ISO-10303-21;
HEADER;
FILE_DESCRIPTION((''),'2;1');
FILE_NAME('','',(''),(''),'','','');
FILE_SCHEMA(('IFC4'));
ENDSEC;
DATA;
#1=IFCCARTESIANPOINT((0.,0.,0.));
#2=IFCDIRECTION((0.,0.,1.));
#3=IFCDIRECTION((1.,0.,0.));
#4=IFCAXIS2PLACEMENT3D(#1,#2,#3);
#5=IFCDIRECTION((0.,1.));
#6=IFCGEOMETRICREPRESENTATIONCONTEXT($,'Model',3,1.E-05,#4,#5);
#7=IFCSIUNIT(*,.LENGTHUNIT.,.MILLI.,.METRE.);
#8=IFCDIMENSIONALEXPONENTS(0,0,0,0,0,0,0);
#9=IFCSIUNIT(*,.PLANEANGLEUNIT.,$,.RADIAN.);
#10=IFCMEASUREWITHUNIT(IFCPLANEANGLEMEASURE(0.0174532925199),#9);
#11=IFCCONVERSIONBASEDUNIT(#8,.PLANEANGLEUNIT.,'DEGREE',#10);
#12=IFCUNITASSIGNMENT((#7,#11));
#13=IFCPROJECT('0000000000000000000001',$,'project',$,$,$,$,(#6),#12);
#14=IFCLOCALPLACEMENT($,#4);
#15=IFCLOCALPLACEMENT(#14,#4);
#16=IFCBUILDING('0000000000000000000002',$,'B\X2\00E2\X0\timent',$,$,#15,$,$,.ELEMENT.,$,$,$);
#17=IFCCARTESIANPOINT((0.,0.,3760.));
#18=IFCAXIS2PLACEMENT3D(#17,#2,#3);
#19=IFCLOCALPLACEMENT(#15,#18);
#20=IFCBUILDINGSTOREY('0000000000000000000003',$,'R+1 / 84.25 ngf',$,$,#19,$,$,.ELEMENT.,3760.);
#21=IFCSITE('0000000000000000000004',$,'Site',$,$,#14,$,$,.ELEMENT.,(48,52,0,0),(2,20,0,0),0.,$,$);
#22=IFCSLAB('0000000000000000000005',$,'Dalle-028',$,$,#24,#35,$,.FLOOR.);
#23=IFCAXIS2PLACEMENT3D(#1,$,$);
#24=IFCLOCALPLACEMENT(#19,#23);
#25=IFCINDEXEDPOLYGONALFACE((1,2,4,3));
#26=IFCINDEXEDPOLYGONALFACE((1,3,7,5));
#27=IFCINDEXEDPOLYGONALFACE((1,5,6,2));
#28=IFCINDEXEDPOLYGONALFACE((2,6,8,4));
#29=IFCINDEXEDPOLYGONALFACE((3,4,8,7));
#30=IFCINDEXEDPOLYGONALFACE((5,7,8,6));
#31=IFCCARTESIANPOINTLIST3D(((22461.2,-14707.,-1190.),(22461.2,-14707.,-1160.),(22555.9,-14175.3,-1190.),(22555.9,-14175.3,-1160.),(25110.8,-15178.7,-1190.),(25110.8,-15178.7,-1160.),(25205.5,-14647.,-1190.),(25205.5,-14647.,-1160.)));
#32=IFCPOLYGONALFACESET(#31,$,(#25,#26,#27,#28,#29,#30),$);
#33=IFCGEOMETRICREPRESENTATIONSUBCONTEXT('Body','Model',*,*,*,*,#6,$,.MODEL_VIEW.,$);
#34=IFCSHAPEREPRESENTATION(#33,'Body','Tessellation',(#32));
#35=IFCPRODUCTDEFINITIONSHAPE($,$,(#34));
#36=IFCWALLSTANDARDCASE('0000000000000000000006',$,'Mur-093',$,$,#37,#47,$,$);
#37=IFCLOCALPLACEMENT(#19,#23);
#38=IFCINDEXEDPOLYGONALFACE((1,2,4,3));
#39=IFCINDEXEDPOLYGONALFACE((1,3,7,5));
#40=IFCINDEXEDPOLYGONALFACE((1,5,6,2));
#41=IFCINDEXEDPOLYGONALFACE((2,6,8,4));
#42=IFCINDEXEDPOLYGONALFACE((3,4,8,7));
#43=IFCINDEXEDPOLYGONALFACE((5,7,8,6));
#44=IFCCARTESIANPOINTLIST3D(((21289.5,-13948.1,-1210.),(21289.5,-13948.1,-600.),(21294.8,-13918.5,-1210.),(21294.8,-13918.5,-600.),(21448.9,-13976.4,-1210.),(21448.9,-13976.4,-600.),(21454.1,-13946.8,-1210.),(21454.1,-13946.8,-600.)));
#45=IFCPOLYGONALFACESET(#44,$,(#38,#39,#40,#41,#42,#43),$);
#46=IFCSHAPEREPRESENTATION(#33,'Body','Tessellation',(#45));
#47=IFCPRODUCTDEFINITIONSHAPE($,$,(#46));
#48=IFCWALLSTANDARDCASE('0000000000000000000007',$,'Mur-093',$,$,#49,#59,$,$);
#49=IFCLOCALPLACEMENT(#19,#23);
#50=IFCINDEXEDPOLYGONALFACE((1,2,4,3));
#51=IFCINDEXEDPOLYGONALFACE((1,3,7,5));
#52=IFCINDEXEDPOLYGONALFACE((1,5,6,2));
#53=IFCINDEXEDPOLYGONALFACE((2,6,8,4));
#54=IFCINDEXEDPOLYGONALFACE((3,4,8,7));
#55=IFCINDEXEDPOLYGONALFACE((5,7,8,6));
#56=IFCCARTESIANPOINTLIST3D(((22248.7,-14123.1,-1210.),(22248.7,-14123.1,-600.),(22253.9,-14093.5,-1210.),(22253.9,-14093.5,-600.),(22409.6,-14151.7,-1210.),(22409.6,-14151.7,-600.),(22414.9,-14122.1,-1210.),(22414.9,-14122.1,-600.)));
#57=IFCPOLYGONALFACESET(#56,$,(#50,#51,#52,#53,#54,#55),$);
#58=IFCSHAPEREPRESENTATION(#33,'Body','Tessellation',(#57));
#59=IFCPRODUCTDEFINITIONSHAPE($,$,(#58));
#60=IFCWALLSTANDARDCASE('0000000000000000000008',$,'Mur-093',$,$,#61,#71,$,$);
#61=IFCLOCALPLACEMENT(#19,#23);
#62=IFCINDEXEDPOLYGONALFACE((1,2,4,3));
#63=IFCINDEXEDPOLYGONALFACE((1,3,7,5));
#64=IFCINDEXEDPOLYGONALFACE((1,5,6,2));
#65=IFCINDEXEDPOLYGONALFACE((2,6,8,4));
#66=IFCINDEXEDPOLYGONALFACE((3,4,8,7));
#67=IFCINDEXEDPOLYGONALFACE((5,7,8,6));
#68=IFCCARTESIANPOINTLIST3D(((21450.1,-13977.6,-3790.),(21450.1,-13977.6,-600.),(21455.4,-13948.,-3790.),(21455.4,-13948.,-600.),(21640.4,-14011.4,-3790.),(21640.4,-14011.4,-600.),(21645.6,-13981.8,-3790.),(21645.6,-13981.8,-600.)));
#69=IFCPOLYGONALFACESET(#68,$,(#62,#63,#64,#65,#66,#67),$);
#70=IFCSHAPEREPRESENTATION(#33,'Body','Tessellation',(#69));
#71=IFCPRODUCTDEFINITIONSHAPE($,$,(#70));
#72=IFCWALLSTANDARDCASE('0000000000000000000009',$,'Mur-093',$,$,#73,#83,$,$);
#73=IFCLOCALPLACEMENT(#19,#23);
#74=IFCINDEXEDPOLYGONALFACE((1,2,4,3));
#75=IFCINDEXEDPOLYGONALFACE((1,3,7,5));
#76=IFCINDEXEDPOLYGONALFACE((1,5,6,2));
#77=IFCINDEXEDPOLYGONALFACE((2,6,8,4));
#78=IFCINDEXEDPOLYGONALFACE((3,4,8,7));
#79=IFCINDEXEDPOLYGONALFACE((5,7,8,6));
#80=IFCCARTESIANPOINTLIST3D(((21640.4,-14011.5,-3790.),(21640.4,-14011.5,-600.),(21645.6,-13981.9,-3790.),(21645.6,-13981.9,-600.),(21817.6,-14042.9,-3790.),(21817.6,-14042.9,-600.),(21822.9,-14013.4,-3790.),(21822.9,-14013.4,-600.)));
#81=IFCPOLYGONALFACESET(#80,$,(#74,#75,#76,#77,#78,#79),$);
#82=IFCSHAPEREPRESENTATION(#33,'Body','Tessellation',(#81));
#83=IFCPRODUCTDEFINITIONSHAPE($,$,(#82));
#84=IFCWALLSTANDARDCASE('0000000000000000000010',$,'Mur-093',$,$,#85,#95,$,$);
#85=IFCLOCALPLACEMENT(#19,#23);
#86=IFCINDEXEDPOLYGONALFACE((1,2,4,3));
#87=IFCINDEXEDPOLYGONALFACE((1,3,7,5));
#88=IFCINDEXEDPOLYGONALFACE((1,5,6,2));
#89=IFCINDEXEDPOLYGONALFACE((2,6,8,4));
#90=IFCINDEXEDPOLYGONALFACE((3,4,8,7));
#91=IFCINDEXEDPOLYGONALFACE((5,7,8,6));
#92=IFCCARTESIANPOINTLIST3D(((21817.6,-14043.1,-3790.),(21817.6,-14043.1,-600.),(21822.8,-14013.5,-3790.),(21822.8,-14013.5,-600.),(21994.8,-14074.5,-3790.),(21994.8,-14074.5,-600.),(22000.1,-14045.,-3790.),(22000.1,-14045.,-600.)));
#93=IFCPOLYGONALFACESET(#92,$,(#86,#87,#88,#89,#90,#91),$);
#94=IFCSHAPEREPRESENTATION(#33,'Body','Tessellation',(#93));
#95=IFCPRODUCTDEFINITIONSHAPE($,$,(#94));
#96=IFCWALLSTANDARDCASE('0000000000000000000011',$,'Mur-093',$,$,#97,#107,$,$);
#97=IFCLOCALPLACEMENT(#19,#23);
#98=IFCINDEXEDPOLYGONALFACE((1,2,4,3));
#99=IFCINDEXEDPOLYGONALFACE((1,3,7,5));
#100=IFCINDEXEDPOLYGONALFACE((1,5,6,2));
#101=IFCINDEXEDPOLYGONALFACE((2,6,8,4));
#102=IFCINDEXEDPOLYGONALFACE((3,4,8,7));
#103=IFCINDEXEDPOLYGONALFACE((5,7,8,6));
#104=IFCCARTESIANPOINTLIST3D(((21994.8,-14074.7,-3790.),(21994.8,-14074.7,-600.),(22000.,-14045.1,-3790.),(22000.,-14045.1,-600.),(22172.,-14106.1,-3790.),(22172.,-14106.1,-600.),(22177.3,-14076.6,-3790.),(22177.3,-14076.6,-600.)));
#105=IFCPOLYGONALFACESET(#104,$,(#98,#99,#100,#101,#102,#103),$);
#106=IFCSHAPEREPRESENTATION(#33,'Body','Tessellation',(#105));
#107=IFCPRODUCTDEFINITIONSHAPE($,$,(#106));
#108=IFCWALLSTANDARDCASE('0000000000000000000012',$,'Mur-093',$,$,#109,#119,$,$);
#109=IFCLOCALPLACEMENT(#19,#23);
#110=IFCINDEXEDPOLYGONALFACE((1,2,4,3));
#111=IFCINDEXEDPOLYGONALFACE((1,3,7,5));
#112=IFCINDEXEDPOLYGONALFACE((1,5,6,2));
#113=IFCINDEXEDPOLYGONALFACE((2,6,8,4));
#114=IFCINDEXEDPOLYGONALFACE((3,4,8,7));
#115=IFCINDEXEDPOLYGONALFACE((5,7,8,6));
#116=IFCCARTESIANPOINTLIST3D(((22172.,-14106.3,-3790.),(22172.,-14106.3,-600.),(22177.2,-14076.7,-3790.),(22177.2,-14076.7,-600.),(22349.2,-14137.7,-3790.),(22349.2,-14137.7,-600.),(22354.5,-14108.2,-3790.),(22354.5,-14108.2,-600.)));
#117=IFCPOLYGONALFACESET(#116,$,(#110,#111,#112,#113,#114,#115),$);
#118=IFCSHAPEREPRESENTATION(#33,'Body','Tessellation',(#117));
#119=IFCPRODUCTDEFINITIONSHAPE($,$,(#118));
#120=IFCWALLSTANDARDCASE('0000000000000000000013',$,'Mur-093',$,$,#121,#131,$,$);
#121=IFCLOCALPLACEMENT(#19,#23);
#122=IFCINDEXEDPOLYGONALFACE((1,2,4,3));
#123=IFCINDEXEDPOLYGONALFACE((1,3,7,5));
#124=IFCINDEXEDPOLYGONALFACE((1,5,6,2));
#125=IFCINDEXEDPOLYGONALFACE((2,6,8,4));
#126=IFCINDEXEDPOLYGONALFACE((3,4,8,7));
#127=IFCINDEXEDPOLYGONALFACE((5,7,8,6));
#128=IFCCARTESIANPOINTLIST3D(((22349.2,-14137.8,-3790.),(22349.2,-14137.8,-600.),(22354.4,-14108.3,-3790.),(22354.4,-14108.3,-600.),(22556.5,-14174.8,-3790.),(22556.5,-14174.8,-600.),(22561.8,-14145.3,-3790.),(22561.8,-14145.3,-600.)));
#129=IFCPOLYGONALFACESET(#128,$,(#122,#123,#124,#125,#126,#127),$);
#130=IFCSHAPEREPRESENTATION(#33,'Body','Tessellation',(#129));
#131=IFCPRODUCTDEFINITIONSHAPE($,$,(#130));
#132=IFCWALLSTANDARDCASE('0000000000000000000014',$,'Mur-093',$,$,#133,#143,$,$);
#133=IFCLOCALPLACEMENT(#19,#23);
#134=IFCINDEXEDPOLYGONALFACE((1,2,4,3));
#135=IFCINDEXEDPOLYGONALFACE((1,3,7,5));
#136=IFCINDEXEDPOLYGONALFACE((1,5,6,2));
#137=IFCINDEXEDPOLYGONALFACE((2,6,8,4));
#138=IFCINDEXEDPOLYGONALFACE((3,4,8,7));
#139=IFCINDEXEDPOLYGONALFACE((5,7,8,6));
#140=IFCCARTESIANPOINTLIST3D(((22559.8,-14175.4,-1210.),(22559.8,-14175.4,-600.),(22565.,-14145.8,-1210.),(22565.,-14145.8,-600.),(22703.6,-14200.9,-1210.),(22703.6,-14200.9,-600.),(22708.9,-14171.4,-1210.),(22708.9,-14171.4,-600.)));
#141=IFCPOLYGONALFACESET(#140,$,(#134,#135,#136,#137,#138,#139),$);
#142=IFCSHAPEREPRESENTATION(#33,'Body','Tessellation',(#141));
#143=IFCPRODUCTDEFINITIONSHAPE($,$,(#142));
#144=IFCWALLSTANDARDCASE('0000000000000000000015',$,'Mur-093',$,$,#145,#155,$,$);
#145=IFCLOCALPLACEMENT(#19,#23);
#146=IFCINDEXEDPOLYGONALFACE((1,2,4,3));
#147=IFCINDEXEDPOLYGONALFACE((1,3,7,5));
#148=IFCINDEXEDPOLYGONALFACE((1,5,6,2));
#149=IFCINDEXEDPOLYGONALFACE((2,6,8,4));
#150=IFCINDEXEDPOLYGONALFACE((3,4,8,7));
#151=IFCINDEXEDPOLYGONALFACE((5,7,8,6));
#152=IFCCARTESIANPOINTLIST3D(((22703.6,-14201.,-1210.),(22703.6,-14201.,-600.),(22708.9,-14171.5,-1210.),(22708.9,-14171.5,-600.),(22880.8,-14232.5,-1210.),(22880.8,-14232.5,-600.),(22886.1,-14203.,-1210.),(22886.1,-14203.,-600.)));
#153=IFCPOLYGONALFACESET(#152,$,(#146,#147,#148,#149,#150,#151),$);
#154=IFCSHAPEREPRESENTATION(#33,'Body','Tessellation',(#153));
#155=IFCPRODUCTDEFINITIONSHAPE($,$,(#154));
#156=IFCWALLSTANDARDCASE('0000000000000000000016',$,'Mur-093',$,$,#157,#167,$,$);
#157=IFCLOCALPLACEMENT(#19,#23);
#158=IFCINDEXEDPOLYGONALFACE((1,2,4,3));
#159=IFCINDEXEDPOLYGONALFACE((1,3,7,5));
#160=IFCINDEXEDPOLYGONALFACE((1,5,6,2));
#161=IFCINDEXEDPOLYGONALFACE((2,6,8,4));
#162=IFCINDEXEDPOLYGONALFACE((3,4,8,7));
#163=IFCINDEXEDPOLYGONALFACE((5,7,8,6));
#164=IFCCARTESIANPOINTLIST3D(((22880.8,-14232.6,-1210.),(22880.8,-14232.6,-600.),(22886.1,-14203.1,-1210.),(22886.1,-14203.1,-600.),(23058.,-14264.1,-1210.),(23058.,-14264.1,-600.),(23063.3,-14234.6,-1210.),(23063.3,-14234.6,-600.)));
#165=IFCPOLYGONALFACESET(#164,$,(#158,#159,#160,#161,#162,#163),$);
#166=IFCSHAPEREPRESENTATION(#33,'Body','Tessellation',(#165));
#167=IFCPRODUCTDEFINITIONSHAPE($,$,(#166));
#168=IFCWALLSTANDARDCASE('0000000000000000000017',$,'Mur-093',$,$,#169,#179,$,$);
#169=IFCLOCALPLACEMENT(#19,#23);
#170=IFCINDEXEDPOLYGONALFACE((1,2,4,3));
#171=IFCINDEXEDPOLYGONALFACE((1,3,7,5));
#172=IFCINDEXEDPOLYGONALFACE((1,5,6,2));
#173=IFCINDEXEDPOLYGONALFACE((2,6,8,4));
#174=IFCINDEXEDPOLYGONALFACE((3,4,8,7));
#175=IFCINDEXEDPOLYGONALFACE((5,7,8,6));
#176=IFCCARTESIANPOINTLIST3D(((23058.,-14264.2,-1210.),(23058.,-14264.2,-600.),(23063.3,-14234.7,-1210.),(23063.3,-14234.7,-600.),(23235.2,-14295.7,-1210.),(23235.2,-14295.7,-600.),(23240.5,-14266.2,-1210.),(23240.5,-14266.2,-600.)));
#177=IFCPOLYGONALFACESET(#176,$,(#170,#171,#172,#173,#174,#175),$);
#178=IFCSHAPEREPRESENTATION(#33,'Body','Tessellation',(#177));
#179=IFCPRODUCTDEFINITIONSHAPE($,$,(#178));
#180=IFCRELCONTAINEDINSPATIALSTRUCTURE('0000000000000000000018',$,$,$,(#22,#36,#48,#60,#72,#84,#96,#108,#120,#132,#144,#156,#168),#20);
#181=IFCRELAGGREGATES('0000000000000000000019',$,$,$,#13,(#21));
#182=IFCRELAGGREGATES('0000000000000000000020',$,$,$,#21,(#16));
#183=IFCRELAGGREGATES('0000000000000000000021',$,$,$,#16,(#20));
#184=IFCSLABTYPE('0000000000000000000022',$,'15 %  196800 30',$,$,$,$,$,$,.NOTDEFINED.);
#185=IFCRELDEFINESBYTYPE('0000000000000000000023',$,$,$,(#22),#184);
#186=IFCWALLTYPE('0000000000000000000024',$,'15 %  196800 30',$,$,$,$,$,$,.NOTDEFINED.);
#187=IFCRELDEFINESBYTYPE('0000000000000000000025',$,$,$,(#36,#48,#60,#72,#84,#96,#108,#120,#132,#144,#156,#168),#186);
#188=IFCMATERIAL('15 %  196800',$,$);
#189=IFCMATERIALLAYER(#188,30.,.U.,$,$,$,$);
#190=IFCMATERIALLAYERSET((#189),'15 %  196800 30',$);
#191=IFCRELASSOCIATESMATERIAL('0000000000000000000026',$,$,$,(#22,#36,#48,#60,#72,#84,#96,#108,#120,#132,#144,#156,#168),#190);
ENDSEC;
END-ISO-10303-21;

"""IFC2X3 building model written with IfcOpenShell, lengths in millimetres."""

from ifc_helpers import new_model, entity, si_unit, converted_unit, direction, frame, origin_with_axes, place, context, subcontext, project, spatial, polyline, outline, extrude, material, layer, layer_set, layer_usage, type_object, element, save


model = new_model("IFC2X3")

# Units and contexts
model_context = context("Model", 3, precision=1e-05, world=origin_with_axes(), true_north=direction((0.0, 1.0)))
body_context = subcontext(model_context, "Body", "Model", "MODEL_VIEW")
ifc_project = project(units=[si_unit("LENGTHUNIT", "METRE", prefix="MILLI"), converted_unit("PLANEANGLEUNIT", "DEGREE", entity("IfcPlaneAngleMeasure", 0.0174532925199), si_unit("PLANEANGLEUNIT", "RADIAN"), dimensions=[0, 0, 0, 0, 0, 0, 0])], contexts=[model_context])

# Site, building, storey
site_placement = place(None, origin_with_axes())
site = spatial("IfcSite", under=ifc_project, at=site_placement, Name="Site", CompositionType="ELEMENT", RefLatitude=(48, 52, 0, 0), RefLongitude=(2, 20, 0, 0), RefElevation=0.0)
building_placement = place(site_placement, origin_with_axes())
building = spatial("IfcBuilding", under=site, at=building_placement, Name="Bâtiment", CompositionType="ELEMENT")
storey_placement = place(building_placement, frame((0.0, 0.0, 3760.0), z_axis=(0.0, 0.0, 1.0), x_axis=(1.0, 0.0, 0.0)))
storey = spatial("IfcBuildingStorey", under=building, at=storey_placement, Name="R+1 / 84.25 ngf", CompositionType="ELEMENT", Elevation=3760.0)

# Slab
ifc_material = material(Name="15 %  196800")
ifc_layer = layer(ifc_material, 30.0, ventilated="UNKNOWN")
ifc_layer_set = layer_set([ifc_layer], Name="15 %  196800 30")
ifc_layer_usage_1 = layer_usage(ifc_layer_set, "AXIS3", "NEGATIVE", 30.0)
slab_type = type_object("IfcSlabType", Name="15 %  196800 30", PredefinedType="NOTDEFINED")
slab_placement = place(storey_placement, frame((22461.2, -14707.0, -1160.0), z_axis=(0.0, 0.0, 1.0), x_axis=(1.0, 0.0, 0.0)))
element("IfcSlab", 1, at=slab_placement, inside=storey, type_object=slab_type, material=ifc_layer_usage_1, Name="Dalle-028", PredefinedType="FLOOR", context=body_context, shape_type="SweptSolid", body=[
    extrude(outline(polyline([(0.0, 0.0), (2649.6, -471.7), (2744.3, 60.0), (94.7, 531.7), (0.0, 0.0)])), frame((0.0, 0.0, -30.0), z_axis=(0.0, 0.0, 1.0), x_axis=(1.0, 0.0, 0.0)), (0.0, 0.0, 1.0), 30.0),
])

# Walls
ifc_layer_usage_2 = layer_usage(ifc_layer_set, "AXIS2", "NEGATIVE", 30.0)
wall_type = type_object("IfcWallType", Name="15 %  196800 30", PredefinedType="NOTDEFINED")
wall_1_placement = place(storey_placement, frame((21454.1, -13946.8, -1210.0), z_axis=(0.0, 0.0, 1.0), x_axis=(-0.984592, 0.174869, 0.0)))
element("IfcWallStandardCase", 2, at=wall_1_placement, inside=storey, type_object=wall_type, material=ifc_layer_usage_2, Name="Mur-093", context=body_context, shape_type="SweptSolid", body=[
    extrude(outline(polyline([(0.0, 0.0), (161.9, 0.0), (161.9, 30.0), (0.0, 30.0), (0.0, 0.0)])), origin_with_axes(), (0.0, 0.0, 1.0), 610.0),
])
ifc_layer_usage_3 = layer_usage(ifc_layer_set, "AXIS2", "NEGATIVE", 30.0)
wall_2_placement = place(storey_placement, frame((22414.9, -14122.1, -1210.0), z_axis=(0.0, 0.0, 1.0), x_axis=(-0.984592, 0.174869, 0.0)))
element("IfcWallStandardCase", 3, at=wall_2_placement, inside=storey, type_object=wall_type, material=ifc_layer_usage_3, Name="Mur-093", context=body_context, shape_type="SweptSolid", body=[
    extrude(outline(polyline([(0.0, 0.0), (163.5, 0.0), (163.5, 30.0), (0.0, 30.0), (0.0, 0.0)])), origin_with_axes(), (0.0, 0.0, 1.0), 610.0),
])
ifc_layer_usage_4 = layer_usage(ifc_layer_set, "AXIS2", "NEGATIVE", 30.0)
wall_3_placement = place(storey_placement, frame((21645.6, -13981.8, -3790.0), z_axis=(0.0, 0.0, 1.0), x_axis=(-0.984592, 0.174869, 0.0)))
element("IfcWallStandardCase", 4, at=wall_3_placement, inside=storey, type_object=wall_type, material=ifc_layer_usage_4, Name="Mur-093", context=body_context, shape_type="SweptSolid", body=[
    extrude(outline(polyline([(0.0, 0.0), (193.3, 0.0), (193.3, 30.0), (0.0, 30.0), (0.0, 0.0)])), origin_with_axes(), (0.0, 0.0, 1.0), 3190.0),
])
ifc_layer_usage_5 = layer_usage(ifc_layer_set, "AXIS2", "NEGATIVE", 30.0)
wall_4_placement = place(storey_placement, frame((21822.9, -14013.4, -3790.0), z_axis=(0.0, 0.0, 1.0), x_axis=(-0.984592, 0.174869, 0.0)))
element("IfcWallStandardCase", 5, at=wall_4_placement, inside=storey, type_object=wall_type, material=ifc_layer_usage_5, Name="Mur-093", context=body_context, shape_type="SweptSolid", body=[
    extrude(outline(polyline([(0.0, 0.0), (180.0, 0.0), (180.0, 30.0), (0.0, 30.0), (0.0, 0.0)])), origin_with_axes(), (0.0, 0.0, 1.0), 3190.0),
])
ifc_layer_usage_6 = layer_usage(ifc_layer_set, "AXIS2", "NEGATIVE", 30.0)
wall_5_placement = place(storey_placement, frame((22000.1, -14045.0, -3790.0), z_axis=(0.0, 0.0, 1.0), x_axis=(-0.984592, 0.174869, 0.0)))
element("IfcWallStandardCase", 6, at=wall_5_placement, inside=storey, type_object=wall_type, material=ifc_layer_usage_6, Name="Mur-093", context=body_context, shape_type="SweptSolid", body=[
    extrude(outline(polyline([(0.0, 0.0), (180.0, 0.0), (180.0, 30.0), (0.0, 30.0), (0.0, 0.0)])), origin_with_axes(), (0.0, 0.0, 1.0), 3190.0),
])
ifc_layer_usage_7 = layer_usage(ifc_layer_set, "AXIS2", "NEGATIVE", 30.0)
wall_6_placement = place(storey_placement, frame((22177.3, -14076.6, -3790.0), z_axis=(0.0, 0.0, 1.0), x_axis=(-0.984592, 0.174869, 0.0)))
element("IfcWallStandardCase", 7, at=wall_6_placement, inside=storey, type_object=wall_type, material=ifc_layer_usage_7, Name="Mur-093", context=body_context, shape_type="SweptSolid", body=[
    extrude(outline(polyline([(0.0, 0.0), (180.0, 0.0), (180.0, 30.0), (0.0, 30.0), (0.0, 0.0)])), origin_with_axes(), (0.0, 0.0, 1.0), 3190.0),
])
ifc_layer_usage_8 = layer_usage(ifc_layer_set, "AXIS2", "NEGATIVE", 30.0)
wall_7_placement = place(storey_placement, frame((22354.5, -14108.2, -3790.0), z_axis=(0.0, 0.0, 1.0), x_axis=(-0.984592, 0.174869, 0.0)))
element("IfcWallStandardCase", 8, at=wall_7_placement, inside=storey, type_object=wall_type, material=ifc_layer_usage_8, Name="Mur-093", context=body_context, shape_type="SweptSolid", body=[
    extrude(outline(polyline([(0.0, 0.0), (180.0, 0.0), (180.0, 30.0), (0.0, 30.0), (0.0, 0.0)])), origin_with_axes(), (0.0, 0.0, 1.0), 3190.0),
])
ifc_layer_usage_9 = layer_usage(ifc_layer_set, "AXIS2", "NEGATIVE", 30.0)
wall_8_placement = place(storey_placement, frame((22561.8, -14145.3, -3790.0), z_axis=(0.0, 0.0, 1.0), x_axis=(-0.984492, 0.175429, 0.0)))
element("IfcWallStandardCase", 9, at=wall_8_placement, inside=storey, type_object=wall_type, material=ifc_layer_usage_9, Name="Mur-093", context=body_context, shape_type="SweptSolid", body=[
    extrude(outline(polyline([(0.0, 0.0), (210.6, 0.0), (210.6, 30.0), (0.0, 30.0), (0.0, 0.0)])), origin_with_axes(), (0.0, 0.0, 1.0), 3190.0),
])
ifc_layer_usage_10 = layer_usage(ifc_layer_set, "AXIS2", "NEGATIVE", 30.0)
wall_9_placement = place(storey_placement, frame((22708.9, -14171.4, -1210.0), z_axis=(0.0, 0.0, 1.0), x_axis=(-0.984592, 0.174869, 0.0)))
element("IfcWallStandardCase", 10, at=wall_9_placement, inside=storey, type_object=wall_type, material=ifc_layer_usage_10, Name="Mur-093", context=body_context, shape_type="SweptSolid", body=[
    extrude(outline(polyline([(0.0, 0.0), (146.1, 0.0), (146.1, 30.0), (0.0, 30.0), (0.0, 0.0)])), origin_with_axes(), (0.0, 0.0, 1.0), 610.0),
])
ifc_layer_usage_11 = layer_usage(ifc_layer_set, "AXIS2", "NEGATIVE", 30.0)
wall_10_placement = place(storey_placement, frame((22886.1, -14203.0, -1210.0), z_axis=(0.0, 0.0, 1.0), x_axis=(-0.984592, 0.174869, 0.0)))
element("IfcWallStandardCase", 11, at=wall_10_placement, inside=storey, type_object=wall_type, material=ifc_layer_usage_11, Name="Mur-093", context=body_context, shape_type="SweptSolid", body=[
    extrude(outline(polyline([(0.0, 0.0), (180.0, 0.0), (180.0, 30.0), (0.0, 30.0), (0.0, 0.0)])), origin_with_axes(), (0.0, 0.0, 1.0), 610.0),
])
ifc_layer_usage_12 = layer_usage(ifc_layer_set, "AXIS2", "NEGATIVE", 30.0)
wall_11_placement = place(storey_placement, frame((23063.3, -14234.6, -1210.0), z_axis=(0.0, 0.0, 1.0), x_axis=(-0.984592, 0.174869, 0.0)))
element("IfcWallStandardCase", 12, at=wall_11_placement, inside=storey, type_object=wall_type, material=ifc_layer_usage_12, Name="Mur-093", context=body_context, shape_type="SweptSolid", body=[
    extrude(outline(polyline([(0.0, 0.0), (180.0, 0.0), (180.0, 30.0), (0.0, 30.0), (0.0, 0.0)])), origin_with_axes(), (0.0, 0.0, 1.0), 610.0),
])
ifc_layer_usage_13 = layer_usage(ifc_layer_set, "AXIS2", "NEGATIVE", 30.0)
wall_12_placement = place(storey_placement, frame((23240.5, -14266.2, -1210.0), z_axis=(0.0, 0.0, 1.0), x_axis=(-0.984592, 0.174869, 0.0)))
element("IfcWallStandardCase", 13, at=wall_12_placement, inside=storey, type_object=wall_type, material=ifc_layer_usage_13, Name="Mur-093", context=body_context, shape_type="SweptSolid", body=[
    extrude(outline(polyline([(0.0, 0.0), (180.0, 0.0), (180.0, 30.0), (0.0, 30.0), (0.0, 0.0)])), origin_with_axes(), (0.0, 0.0, 1.0), 610.0),
])

save(model, "model.ifc")
